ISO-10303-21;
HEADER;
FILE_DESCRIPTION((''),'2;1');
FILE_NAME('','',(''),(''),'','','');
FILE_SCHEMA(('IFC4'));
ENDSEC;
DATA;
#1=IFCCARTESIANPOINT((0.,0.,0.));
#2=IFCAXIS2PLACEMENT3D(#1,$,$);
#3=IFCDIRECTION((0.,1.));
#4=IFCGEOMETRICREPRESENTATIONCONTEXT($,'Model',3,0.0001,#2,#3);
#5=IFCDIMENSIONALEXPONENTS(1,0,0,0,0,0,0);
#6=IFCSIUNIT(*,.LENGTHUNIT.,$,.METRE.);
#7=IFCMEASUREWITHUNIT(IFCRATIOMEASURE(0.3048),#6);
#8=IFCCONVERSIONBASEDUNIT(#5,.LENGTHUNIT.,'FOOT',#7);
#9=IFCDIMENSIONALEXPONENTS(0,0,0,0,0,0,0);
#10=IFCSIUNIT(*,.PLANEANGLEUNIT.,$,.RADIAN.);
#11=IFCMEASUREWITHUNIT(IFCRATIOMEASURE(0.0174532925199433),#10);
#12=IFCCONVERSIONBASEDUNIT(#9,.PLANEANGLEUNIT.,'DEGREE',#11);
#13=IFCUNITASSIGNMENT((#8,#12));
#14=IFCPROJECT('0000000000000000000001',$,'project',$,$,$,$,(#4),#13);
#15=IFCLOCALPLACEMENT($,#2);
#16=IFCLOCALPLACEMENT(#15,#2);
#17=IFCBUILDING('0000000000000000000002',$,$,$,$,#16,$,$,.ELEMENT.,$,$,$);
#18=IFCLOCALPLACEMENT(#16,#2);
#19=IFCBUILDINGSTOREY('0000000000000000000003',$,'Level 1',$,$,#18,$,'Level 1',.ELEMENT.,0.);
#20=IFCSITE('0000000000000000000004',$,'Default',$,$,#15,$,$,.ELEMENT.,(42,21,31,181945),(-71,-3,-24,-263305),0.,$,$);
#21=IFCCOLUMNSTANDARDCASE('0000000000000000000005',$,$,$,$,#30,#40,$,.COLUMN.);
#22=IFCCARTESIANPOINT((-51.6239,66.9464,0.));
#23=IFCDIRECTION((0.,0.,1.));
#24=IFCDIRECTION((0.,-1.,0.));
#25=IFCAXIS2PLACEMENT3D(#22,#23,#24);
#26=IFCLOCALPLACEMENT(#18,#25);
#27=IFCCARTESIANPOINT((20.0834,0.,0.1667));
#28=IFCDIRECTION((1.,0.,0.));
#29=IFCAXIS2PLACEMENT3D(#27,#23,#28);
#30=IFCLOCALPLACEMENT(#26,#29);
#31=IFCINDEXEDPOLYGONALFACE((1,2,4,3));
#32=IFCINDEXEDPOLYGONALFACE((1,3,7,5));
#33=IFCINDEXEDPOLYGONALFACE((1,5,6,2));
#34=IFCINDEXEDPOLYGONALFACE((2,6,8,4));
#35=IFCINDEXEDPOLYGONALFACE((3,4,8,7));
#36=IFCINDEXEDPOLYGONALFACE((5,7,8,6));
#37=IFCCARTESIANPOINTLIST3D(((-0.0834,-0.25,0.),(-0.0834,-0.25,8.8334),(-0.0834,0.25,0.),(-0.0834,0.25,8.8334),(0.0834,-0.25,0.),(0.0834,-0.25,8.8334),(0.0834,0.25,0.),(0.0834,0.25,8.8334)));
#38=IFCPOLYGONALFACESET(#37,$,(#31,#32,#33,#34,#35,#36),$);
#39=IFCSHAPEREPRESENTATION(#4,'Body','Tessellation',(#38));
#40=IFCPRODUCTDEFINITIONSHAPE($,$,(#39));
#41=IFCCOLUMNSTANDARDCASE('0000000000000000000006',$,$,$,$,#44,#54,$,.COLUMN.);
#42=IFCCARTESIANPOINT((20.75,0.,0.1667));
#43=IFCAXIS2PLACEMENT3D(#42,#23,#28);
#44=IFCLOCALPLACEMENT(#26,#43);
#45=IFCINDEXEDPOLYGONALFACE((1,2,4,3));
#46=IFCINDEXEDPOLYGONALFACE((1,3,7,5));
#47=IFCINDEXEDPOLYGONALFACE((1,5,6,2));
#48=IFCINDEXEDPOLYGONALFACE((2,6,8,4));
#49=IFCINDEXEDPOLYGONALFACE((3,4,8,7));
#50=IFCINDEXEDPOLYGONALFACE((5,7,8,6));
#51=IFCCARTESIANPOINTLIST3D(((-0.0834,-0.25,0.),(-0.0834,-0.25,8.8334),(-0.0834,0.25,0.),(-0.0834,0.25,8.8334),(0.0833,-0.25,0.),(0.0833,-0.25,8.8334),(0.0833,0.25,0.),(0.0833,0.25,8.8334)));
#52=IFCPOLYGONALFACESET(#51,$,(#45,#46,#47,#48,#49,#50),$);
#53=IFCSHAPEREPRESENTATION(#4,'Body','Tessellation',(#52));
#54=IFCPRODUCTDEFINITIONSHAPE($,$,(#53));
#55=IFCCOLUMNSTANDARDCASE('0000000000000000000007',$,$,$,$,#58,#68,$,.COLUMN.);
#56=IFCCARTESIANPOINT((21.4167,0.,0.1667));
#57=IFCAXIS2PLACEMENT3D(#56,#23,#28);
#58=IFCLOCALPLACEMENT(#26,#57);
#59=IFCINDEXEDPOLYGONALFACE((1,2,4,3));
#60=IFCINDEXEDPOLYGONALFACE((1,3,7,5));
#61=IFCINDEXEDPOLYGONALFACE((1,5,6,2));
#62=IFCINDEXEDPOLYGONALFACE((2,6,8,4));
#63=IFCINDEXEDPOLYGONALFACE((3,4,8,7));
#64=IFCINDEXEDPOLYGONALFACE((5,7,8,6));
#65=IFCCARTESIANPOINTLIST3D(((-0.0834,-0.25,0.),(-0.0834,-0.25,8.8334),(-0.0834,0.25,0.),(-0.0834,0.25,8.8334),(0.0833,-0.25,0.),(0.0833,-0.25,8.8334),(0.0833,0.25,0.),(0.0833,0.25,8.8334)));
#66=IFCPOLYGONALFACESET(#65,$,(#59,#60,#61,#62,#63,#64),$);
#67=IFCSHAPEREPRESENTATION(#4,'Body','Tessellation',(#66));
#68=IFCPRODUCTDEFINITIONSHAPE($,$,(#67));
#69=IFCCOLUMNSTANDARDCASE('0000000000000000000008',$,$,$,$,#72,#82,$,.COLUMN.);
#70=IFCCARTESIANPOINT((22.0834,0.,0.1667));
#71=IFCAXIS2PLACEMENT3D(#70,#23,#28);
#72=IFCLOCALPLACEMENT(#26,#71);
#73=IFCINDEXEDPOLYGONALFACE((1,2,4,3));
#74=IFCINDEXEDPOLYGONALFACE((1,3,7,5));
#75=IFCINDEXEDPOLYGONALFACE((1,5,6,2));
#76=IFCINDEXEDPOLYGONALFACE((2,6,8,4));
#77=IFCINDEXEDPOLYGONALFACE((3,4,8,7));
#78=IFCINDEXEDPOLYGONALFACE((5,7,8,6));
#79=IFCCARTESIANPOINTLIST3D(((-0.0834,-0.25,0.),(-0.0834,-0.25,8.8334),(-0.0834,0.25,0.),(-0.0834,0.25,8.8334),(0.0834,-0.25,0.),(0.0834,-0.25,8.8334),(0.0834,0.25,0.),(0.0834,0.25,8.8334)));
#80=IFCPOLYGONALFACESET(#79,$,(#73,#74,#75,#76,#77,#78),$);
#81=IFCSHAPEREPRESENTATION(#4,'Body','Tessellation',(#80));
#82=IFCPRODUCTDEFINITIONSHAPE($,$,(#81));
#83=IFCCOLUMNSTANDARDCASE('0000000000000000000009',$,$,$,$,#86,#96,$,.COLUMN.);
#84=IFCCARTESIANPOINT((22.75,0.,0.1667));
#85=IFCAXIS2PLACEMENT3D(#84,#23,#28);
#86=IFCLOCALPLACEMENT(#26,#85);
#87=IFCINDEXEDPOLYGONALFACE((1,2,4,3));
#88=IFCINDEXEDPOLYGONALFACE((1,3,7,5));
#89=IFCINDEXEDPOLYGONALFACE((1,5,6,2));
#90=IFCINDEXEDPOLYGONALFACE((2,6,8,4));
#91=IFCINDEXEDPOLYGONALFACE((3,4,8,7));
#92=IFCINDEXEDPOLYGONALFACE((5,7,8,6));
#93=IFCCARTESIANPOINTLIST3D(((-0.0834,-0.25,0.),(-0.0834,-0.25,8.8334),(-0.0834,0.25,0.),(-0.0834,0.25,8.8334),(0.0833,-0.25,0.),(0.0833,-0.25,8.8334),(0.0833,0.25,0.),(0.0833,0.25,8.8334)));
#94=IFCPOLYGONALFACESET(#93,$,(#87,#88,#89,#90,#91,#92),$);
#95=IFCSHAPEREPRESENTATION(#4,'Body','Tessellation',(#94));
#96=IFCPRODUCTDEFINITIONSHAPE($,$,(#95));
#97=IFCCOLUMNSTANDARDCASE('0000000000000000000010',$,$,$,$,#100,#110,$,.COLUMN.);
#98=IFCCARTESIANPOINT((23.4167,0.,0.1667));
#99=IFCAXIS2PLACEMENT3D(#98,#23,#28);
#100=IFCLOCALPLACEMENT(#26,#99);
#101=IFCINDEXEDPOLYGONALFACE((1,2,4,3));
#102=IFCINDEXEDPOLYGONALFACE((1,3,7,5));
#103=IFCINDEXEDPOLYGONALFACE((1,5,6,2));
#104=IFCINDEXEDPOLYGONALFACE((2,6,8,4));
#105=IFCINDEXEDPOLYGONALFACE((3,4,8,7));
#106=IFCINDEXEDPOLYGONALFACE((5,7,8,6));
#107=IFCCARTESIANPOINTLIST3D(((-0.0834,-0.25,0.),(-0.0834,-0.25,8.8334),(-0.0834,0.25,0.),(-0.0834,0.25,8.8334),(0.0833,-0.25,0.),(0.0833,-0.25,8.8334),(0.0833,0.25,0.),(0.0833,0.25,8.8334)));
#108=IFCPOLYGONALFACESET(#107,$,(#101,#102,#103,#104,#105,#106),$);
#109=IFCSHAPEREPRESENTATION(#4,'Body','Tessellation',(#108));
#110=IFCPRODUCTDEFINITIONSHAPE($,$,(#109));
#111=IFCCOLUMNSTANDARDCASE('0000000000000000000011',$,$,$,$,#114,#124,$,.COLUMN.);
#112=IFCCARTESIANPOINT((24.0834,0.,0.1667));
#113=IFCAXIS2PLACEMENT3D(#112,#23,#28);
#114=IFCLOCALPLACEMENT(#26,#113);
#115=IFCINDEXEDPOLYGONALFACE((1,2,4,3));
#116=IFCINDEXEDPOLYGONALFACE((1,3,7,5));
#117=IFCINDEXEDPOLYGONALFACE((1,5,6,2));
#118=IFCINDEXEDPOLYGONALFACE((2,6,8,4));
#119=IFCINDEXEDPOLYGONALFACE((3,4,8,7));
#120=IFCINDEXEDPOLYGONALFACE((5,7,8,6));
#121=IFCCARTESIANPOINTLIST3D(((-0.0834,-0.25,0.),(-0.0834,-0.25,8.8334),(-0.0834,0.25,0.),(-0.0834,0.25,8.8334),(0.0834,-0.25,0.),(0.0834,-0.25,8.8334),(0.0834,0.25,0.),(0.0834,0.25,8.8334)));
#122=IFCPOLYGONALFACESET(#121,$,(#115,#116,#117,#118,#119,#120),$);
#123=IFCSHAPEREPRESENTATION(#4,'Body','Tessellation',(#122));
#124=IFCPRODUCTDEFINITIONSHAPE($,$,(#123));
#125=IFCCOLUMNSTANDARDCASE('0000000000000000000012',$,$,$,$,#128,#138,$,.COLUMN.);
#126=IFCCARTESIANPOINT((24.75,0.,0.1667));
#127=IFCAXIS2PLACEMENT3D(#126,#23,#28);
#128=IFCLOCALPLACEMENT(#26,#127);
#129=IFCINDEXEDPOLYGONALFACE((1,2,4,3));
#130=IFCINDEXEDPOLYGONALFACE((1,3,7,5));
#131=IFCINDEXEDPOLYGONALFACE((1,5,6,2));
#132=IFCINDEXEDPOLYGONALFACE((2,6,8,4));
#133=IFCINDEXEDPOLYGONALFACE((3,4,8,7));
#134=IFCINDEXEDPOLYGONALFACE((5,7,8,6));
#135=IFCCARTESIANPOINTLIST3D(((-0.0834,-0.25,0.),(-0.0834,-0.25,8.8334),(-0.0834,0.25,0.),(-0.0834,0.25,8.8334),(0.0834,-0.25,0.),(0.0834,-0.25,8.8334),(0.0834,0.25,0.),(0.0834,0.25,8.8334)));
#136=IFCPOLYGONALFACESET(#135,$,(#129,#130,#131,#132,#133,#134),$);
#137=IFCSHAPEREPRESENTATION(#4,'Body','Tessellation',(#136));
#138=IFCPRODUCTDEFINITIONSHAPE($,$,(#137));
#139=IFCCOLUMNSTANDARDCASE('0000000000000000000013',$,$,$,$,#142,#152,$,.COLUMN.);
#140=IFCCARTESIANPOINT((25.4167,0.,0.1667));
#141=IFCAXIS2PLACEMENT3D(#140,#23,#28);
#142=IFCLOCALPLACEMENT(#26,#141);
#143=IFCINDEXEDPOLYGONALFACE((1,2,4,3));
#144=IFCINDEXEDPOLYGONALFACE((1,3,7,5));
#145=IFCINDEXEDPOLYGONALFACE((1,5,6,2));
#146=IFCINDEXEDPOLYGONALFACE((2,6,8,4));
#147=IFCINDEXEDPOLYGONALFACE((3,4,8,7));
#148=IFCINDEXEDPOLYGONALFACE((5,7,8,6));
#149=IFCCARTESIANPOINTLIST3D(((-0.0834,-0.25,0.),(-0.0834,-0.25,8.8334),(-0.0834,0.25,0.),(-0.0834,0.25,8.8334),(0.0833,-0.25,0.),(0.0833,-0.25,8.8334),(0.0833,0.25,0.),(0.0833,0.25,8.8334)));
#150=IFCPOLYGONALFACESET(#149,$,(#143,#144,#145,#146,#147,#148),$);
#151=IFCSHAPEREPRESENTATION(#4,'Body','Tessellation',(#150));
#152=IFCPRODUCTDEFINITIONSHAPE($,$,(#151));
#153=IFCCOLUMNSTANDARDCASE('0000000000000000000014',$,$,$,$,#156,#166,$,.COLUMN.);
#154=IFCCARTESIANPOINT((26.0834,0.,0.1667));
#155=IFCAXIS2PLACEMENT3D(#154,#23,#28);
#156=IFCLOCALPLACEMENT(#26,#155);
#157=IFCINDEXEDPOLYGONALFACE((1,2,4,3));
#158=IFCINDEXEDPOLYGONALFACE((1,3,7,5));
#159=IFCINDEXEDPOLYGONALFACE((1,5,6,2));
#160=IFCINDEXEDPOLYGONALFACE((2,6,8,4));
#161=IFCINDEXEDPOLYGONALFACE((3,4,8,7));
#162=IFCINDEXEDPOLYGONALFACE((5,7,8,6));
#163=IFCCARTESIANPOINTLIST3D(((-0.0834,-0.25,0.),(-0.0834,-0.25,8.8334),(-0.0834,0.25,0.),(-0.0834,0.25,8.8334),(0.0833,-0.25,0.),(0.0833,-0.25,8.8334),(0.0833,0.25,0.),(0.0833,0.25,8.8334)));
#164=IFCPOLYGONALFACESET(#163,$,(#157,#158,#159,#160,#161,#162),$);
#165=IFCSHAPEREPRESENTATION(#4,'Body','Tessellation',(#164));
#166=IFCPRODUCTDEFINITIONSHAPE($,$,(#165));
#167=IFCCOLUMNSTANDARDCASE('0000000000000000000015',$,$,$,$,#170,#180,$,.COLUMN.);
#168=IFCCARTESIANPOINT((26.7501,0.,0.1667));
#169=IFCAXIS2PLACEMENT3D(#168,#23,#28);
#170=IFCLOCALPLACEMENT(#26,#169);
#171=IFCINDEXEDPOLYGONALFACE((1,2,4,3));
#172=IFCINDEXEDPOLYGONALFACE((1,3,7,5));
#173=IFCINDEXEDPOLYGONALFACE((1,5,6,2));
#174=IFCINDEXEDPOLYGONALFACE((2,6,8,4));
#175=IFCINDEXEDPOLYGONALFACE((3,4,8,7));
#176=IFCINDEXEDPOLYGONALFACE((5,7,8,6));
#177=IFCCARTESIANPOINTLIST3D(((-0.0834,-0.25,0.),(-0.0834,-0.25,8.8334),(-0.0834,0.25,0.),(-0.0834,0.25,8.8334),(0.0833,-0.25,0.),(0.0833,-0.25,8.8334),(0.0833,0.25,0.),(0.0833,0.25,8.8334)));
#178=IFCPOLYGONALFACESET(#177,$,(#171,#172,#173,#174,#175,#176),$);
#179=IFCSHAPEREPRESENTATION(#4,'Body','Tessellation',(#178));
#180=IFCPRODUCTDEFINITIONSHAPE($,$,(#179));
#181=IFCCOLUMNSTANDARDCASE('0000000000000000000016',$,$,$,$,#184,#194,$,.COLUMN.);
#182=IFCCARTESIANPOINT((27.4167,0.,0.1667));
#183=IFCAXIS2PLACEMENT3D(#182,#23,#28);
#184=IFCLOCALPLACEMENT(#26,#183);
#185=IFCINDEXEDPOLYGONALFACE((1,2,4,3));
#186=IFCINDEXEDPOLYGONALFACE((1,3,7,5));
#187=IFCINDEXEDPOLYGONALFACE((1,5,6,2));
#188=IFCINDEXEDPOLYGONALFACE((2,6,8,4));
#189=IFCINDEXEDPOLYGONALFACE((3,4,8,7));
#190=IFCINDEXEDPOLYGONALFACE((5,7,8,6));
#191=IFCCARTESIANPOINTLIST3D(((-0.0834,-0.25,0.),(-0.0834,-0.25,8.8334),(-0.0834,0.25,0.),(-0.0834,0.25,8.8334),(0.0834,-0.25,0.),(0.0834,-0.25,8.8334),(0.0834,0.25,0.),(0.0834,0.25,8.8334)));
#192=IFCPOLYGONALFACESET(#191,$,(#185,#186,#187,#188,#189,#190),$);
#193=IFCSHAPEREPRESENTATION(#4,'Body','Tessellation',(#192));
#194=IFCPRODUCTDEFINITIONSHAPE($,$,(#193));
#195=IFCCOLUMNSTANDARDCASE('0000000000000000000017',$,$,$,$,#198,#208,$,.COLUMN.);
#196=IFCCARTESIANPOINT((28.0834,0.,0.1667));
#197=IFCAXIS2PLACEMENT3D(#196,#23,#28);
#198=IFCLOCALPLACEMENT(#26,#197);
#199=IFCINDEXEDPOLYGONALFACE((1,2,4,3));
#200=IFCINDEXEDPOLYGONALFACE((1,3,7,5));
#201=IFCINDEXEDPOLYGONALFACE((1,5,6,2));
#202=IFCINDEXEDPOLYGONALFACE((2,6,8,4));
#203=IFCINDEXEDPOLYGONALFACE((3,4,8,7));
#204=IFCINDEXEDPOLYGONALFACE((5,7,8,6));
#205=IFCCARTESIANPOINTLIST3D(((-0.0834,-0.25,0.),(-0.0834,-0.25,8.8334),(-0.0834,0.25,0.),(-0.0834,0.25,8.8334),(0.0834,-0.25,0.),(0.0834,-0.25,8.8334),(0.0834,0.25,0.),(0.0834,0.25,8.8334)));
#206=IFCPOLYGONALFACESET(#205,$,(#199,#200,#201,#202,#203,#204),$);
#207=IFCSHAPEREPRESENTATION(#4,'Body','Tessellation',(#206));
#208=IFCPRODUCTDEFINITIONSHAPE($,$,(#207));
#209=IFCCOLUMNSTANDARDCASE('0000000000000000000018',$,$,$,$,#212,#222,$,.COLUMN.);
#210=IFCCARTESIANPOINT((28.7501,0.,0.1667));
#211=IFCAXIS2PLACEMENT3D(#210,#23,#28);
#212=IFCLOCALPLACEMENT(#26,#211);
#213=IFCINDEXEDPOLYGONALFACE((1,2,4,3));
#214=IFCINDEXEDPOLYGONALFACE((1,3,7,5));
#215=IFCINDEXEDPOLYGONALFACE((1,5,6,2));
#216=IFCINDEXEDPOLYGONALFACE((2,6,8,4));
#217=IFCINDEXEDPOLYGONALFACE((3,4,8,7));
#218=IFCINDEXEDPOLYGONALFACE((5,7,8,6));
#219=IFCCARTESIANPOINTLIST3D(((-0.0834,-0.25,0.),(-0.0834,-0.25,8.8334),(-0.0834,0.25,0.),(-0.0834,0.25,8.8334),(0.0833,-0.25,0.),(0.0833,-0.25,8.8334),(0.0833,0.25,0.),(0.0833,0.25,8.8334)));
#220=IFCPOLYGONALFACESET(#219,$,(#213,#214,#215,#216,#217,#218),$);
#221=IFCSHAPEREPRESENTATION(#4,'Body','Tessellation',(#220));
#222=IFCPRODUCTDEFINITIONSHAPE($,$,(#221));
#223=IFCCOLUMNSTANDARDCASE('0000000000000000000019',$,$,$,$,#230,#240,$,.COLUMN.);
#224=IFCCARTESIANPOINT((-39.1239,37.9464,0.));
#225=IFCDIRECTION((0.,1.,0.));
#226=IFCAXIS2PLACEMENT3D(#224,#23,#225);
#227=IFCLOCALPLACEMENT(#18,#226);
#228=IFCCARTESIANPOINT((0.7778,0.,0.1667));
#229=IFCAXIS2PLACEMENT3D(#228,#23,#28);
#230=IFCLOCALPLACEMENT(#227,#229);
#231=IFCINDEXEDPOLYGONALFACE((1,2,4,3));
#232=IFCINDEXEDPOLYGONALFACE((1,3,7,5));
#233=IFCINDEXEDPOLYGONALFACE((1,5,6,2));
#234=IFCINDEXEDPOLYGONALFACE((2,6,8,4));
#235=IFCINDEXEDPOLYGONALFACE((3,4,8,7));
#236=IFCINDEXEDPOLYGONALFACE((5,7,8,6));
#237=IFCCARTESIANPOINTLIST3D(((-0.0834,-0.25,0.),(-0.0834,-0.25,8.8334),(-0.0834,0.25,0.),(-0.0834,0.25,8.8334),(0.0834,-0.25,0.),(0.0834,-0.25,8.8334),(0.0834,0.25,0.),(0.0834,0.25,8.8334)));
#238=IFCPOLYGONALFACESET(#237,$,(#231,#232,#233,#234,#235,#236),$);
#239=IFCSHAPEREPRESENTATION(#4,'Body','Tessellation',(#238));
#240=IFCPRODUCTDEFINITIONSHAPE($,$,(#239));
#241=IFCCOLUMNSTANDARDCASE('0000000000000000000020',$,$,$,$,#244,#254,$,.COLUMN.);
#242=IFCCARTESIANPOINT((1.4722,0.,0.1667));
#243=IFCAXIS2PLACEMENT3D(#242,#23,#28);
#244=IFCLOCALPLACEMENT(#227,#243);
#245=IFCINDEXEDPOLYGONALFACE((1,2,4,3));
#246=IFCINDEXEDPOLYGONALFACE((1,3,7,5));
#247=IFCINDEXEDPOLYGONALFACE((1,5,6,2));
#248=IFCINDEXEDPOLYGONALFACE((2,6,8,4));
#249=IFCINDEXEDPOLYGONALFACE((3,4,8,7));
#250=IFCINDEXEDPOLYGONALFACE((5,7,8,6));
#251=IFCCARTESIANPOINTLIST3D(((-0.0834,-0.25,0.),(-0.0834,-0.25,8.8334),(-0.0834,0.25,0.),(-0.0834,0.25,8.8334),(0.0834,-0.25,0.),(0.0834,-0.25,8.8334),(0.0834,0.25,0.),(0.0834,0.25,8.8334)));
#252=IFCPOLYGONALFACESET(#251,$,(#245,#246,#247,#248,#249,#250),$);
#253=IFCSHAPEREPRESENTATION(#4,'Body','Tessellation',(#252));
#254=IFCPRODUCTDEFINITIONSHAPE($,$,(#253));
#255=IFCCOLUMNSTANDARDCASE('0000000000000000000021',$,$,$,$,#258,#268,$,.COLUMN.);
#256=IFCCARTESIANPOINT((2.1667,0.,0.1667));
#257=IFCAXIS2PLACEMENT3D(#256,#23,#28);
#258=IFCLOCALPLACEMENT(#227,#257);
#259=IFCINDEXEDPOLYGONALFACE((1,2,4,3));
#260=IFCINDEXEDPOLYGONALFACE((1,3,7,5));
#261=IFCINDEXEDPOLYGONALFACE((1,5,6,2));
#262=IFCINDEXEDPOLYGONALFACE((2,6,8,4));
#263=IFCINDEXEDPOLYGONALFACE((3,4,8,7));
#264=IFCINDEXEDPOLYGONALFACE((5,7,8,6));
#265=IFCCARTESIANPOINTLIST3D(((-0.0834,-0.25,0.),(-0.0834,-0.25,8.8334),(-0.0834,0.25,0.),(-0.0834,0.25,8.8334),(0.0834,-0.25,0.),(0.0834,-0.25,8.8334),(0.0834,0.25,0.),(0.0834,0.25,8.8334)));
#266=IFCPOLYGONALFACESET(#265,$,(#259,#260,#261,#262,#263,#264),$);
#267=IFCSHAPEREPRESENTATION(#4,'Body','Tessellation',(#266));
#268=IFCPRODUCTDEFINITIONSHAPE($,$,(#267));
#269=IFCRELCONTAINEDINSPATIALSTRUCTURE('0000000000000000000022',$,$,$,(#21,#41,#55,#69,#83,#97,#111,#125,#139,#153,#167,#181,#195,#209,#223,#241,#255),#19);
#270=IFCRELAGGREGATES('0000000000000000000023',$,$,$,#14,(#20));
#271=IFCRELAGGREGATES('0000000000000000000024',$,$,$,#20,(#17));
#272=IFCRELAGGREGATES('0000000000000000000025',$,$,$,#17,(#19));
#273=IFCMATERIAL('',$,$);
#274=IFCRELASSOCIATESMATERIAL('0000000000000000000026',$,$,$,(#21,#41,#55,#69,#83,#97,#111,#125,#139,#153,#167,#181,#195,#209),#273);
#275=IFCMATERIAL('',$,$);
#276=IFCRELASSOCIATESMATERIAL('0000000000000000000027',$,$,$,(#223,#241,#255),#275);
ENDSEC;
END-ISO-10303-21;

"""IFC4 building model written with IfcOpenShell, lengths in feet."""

from ifc_helpers import new_model, entity, si_unit, converted_unit, direction, frame, origin, place, context, project, spatial, rectangle, extrude, material, element, save


model = new_model("IFC4")

# Units and contexts
model_context = context("Model", 3, precision=0.0001, world=origin(), true_north=direction((0.0, 1.0)))
ifc_project = project(units=[converted_unit("LENGTHUNIT", "FOOT", entity("IfcRatioMeasure", 0.3048), si_unit("LENGTHUNIT", "METRE"), dimensions=[1, 0, 0, 0, 0, 0, 0]), converted_unit("PLANEANGLEUNIT", "DEGREE", entity("IfcRatioMeasure", 0.0174532925199433), si_unit("PLANEANGLEUNIT", "RADIAN"), dimensions=[0, 0, 0, 0, 0, 0, 0])], contexts=[model_context])

# Site, building, storey
site_placement = place(None, origin())
site = spatial("IfcSite", under=ifc_project, at=site_placement, Name="Default", CompositionType="ELEMENT", RefLatitude=(42, 21, 31, 181945), RefLongitude=(-71, -3, -24, -263305), RefElevation=0.0)
building_placement = place(site_placement, origin())
building = spatial("IfcBuilding", under=site, at=building_placement, CompositionType="ELEMENT")
storey_placement = place(building_placement, origin())
storey = spatial("IfcBuildingStorey", under=building, at=storey_placement, Name="Level 1", LongName="Level 1", CompositionType="ELEMENT", Elevation=0.0)

# Columns
ifc_material_1 = material(Name="")
placement_1 = place(storey_placement, frame((-51.6239, 66.9464, 0.0), z_axis=(0.0, 0.0, 1.0), x_axis=(0.0, -1.0, 0.0)))
for number, where, z_axis, x_axis in (
    (1, (20.0834, 0.0, 0.1667), (0.0, 0.0, 1.0), (1.0, 0.0, 0.0)),
    (2, (20.75, 0.0, 0.1667), (0.0, 0.0, 1.0), (1.0, 0.0, 0.0)),
    (3, (21.4167, 0.0, 0.1667), (0.0, 0.0, 1.0), (1.0, 0.0, 0.0)),
    (4, (22.0834, 0.0, 0.1667), (0.0, 0.0, 1.0), (1.0, 0.0, 0.0)),
    (5, (22.75, 0.0, 0.1667), (0.0, 0.0, 1.0), (1.0, 0.0, 0.0)),
    (6, (23.4167, 0.0, 0.1667), (0.0, 0.0, 1.0), (1.0, 0.0, 0.0)),
    (7, (24.0834, 0.0, 0.1667), (0.0, 0.0, 1.0), (1.0, 0.0, 0.0)),
    (8, (24.75, 0.0, 0.1667), (0.0, 0.0, 1.0), (1.0, 0.0, 0.0)),
    (9, (25.4167, 0.0, 0.1667), (0.0, 0.0, 1.0), (1.0, 0.0, 0.0)),
    (10, (26.0834, 0.0, 0.1667), (0.0, 0.0, 1.0), (1.0, 0.0, 0.0)),
    (11, (26.7501, 0.0, 0.1667), (0.0, 0.0, 1.0), (1.0, 0.0, 0.0)),
    (12, (27.4167, 0.0, 0.1667), (0.0, 0.0, 1.0), (1.0, 0.0, 0.0)),
    (13, (28.0834, 0.0, 0.1667), (0.0, 0.0, 1.0), (1.0, 0.0, 0.0)),
    (14, (28.7501, 0.0, 0.1667), (0.0, 0.0, 1.0), (1.0, 0.0, 0.0)),
):
    element("IfcColumnStandardCase", number, at=place(placement_1, frame(where, z_axis=z_axis, x_axis=x_axis)), inside=storey, material=ifc_material_1, PredefinedType="COLUMN", context=model_context, shape_type="SweptSolid", body=[
        extrude(rectangle(XDim=0.1667, YDim=0.5), origin(), (0.0, 0.0, 1.0), 8.8334),
    ])
ifc_material_2 = material(Name="")
placement_2 = place(storey_placement, frame((-39.1239, 37.9464, 0.0), z_axis=(0.0, 0.0, 1.0), x_axis=(0.0, 1.0, 0.0)))
for number, where, z_axis, x_axis in (
    (15, (0.7778, 0.0, 0.1667), (0.0, 0.0, 1.0), (1.0, 0.0, 0.0)),
    (16, (1.4722, 0.0, 0.1667), (0.0, 0.0, 1.0), (1.0, 0.0, 0.0)),
    (17, (2.1667, 0.0, 0.1667), (0.0, 0.0, 1.0), (1.0, 0.0, 0.0)),
):
    element("IfcColumnStandardCase", number, at=place(placement_2, frame(where, z_axis=z_axis, x_axis=x_axis)), inside=storey, material=ifc_material_2, PredefinedType="COLUMN", context=model_context, shape_type="SweptSolid", body=[
        extrude(rectangle(XDim=0.1667, YDim=0.5), origin(), (0.0, 0.0, 1.0), 8.8334),
    ])

save(model, "model.ifc")
